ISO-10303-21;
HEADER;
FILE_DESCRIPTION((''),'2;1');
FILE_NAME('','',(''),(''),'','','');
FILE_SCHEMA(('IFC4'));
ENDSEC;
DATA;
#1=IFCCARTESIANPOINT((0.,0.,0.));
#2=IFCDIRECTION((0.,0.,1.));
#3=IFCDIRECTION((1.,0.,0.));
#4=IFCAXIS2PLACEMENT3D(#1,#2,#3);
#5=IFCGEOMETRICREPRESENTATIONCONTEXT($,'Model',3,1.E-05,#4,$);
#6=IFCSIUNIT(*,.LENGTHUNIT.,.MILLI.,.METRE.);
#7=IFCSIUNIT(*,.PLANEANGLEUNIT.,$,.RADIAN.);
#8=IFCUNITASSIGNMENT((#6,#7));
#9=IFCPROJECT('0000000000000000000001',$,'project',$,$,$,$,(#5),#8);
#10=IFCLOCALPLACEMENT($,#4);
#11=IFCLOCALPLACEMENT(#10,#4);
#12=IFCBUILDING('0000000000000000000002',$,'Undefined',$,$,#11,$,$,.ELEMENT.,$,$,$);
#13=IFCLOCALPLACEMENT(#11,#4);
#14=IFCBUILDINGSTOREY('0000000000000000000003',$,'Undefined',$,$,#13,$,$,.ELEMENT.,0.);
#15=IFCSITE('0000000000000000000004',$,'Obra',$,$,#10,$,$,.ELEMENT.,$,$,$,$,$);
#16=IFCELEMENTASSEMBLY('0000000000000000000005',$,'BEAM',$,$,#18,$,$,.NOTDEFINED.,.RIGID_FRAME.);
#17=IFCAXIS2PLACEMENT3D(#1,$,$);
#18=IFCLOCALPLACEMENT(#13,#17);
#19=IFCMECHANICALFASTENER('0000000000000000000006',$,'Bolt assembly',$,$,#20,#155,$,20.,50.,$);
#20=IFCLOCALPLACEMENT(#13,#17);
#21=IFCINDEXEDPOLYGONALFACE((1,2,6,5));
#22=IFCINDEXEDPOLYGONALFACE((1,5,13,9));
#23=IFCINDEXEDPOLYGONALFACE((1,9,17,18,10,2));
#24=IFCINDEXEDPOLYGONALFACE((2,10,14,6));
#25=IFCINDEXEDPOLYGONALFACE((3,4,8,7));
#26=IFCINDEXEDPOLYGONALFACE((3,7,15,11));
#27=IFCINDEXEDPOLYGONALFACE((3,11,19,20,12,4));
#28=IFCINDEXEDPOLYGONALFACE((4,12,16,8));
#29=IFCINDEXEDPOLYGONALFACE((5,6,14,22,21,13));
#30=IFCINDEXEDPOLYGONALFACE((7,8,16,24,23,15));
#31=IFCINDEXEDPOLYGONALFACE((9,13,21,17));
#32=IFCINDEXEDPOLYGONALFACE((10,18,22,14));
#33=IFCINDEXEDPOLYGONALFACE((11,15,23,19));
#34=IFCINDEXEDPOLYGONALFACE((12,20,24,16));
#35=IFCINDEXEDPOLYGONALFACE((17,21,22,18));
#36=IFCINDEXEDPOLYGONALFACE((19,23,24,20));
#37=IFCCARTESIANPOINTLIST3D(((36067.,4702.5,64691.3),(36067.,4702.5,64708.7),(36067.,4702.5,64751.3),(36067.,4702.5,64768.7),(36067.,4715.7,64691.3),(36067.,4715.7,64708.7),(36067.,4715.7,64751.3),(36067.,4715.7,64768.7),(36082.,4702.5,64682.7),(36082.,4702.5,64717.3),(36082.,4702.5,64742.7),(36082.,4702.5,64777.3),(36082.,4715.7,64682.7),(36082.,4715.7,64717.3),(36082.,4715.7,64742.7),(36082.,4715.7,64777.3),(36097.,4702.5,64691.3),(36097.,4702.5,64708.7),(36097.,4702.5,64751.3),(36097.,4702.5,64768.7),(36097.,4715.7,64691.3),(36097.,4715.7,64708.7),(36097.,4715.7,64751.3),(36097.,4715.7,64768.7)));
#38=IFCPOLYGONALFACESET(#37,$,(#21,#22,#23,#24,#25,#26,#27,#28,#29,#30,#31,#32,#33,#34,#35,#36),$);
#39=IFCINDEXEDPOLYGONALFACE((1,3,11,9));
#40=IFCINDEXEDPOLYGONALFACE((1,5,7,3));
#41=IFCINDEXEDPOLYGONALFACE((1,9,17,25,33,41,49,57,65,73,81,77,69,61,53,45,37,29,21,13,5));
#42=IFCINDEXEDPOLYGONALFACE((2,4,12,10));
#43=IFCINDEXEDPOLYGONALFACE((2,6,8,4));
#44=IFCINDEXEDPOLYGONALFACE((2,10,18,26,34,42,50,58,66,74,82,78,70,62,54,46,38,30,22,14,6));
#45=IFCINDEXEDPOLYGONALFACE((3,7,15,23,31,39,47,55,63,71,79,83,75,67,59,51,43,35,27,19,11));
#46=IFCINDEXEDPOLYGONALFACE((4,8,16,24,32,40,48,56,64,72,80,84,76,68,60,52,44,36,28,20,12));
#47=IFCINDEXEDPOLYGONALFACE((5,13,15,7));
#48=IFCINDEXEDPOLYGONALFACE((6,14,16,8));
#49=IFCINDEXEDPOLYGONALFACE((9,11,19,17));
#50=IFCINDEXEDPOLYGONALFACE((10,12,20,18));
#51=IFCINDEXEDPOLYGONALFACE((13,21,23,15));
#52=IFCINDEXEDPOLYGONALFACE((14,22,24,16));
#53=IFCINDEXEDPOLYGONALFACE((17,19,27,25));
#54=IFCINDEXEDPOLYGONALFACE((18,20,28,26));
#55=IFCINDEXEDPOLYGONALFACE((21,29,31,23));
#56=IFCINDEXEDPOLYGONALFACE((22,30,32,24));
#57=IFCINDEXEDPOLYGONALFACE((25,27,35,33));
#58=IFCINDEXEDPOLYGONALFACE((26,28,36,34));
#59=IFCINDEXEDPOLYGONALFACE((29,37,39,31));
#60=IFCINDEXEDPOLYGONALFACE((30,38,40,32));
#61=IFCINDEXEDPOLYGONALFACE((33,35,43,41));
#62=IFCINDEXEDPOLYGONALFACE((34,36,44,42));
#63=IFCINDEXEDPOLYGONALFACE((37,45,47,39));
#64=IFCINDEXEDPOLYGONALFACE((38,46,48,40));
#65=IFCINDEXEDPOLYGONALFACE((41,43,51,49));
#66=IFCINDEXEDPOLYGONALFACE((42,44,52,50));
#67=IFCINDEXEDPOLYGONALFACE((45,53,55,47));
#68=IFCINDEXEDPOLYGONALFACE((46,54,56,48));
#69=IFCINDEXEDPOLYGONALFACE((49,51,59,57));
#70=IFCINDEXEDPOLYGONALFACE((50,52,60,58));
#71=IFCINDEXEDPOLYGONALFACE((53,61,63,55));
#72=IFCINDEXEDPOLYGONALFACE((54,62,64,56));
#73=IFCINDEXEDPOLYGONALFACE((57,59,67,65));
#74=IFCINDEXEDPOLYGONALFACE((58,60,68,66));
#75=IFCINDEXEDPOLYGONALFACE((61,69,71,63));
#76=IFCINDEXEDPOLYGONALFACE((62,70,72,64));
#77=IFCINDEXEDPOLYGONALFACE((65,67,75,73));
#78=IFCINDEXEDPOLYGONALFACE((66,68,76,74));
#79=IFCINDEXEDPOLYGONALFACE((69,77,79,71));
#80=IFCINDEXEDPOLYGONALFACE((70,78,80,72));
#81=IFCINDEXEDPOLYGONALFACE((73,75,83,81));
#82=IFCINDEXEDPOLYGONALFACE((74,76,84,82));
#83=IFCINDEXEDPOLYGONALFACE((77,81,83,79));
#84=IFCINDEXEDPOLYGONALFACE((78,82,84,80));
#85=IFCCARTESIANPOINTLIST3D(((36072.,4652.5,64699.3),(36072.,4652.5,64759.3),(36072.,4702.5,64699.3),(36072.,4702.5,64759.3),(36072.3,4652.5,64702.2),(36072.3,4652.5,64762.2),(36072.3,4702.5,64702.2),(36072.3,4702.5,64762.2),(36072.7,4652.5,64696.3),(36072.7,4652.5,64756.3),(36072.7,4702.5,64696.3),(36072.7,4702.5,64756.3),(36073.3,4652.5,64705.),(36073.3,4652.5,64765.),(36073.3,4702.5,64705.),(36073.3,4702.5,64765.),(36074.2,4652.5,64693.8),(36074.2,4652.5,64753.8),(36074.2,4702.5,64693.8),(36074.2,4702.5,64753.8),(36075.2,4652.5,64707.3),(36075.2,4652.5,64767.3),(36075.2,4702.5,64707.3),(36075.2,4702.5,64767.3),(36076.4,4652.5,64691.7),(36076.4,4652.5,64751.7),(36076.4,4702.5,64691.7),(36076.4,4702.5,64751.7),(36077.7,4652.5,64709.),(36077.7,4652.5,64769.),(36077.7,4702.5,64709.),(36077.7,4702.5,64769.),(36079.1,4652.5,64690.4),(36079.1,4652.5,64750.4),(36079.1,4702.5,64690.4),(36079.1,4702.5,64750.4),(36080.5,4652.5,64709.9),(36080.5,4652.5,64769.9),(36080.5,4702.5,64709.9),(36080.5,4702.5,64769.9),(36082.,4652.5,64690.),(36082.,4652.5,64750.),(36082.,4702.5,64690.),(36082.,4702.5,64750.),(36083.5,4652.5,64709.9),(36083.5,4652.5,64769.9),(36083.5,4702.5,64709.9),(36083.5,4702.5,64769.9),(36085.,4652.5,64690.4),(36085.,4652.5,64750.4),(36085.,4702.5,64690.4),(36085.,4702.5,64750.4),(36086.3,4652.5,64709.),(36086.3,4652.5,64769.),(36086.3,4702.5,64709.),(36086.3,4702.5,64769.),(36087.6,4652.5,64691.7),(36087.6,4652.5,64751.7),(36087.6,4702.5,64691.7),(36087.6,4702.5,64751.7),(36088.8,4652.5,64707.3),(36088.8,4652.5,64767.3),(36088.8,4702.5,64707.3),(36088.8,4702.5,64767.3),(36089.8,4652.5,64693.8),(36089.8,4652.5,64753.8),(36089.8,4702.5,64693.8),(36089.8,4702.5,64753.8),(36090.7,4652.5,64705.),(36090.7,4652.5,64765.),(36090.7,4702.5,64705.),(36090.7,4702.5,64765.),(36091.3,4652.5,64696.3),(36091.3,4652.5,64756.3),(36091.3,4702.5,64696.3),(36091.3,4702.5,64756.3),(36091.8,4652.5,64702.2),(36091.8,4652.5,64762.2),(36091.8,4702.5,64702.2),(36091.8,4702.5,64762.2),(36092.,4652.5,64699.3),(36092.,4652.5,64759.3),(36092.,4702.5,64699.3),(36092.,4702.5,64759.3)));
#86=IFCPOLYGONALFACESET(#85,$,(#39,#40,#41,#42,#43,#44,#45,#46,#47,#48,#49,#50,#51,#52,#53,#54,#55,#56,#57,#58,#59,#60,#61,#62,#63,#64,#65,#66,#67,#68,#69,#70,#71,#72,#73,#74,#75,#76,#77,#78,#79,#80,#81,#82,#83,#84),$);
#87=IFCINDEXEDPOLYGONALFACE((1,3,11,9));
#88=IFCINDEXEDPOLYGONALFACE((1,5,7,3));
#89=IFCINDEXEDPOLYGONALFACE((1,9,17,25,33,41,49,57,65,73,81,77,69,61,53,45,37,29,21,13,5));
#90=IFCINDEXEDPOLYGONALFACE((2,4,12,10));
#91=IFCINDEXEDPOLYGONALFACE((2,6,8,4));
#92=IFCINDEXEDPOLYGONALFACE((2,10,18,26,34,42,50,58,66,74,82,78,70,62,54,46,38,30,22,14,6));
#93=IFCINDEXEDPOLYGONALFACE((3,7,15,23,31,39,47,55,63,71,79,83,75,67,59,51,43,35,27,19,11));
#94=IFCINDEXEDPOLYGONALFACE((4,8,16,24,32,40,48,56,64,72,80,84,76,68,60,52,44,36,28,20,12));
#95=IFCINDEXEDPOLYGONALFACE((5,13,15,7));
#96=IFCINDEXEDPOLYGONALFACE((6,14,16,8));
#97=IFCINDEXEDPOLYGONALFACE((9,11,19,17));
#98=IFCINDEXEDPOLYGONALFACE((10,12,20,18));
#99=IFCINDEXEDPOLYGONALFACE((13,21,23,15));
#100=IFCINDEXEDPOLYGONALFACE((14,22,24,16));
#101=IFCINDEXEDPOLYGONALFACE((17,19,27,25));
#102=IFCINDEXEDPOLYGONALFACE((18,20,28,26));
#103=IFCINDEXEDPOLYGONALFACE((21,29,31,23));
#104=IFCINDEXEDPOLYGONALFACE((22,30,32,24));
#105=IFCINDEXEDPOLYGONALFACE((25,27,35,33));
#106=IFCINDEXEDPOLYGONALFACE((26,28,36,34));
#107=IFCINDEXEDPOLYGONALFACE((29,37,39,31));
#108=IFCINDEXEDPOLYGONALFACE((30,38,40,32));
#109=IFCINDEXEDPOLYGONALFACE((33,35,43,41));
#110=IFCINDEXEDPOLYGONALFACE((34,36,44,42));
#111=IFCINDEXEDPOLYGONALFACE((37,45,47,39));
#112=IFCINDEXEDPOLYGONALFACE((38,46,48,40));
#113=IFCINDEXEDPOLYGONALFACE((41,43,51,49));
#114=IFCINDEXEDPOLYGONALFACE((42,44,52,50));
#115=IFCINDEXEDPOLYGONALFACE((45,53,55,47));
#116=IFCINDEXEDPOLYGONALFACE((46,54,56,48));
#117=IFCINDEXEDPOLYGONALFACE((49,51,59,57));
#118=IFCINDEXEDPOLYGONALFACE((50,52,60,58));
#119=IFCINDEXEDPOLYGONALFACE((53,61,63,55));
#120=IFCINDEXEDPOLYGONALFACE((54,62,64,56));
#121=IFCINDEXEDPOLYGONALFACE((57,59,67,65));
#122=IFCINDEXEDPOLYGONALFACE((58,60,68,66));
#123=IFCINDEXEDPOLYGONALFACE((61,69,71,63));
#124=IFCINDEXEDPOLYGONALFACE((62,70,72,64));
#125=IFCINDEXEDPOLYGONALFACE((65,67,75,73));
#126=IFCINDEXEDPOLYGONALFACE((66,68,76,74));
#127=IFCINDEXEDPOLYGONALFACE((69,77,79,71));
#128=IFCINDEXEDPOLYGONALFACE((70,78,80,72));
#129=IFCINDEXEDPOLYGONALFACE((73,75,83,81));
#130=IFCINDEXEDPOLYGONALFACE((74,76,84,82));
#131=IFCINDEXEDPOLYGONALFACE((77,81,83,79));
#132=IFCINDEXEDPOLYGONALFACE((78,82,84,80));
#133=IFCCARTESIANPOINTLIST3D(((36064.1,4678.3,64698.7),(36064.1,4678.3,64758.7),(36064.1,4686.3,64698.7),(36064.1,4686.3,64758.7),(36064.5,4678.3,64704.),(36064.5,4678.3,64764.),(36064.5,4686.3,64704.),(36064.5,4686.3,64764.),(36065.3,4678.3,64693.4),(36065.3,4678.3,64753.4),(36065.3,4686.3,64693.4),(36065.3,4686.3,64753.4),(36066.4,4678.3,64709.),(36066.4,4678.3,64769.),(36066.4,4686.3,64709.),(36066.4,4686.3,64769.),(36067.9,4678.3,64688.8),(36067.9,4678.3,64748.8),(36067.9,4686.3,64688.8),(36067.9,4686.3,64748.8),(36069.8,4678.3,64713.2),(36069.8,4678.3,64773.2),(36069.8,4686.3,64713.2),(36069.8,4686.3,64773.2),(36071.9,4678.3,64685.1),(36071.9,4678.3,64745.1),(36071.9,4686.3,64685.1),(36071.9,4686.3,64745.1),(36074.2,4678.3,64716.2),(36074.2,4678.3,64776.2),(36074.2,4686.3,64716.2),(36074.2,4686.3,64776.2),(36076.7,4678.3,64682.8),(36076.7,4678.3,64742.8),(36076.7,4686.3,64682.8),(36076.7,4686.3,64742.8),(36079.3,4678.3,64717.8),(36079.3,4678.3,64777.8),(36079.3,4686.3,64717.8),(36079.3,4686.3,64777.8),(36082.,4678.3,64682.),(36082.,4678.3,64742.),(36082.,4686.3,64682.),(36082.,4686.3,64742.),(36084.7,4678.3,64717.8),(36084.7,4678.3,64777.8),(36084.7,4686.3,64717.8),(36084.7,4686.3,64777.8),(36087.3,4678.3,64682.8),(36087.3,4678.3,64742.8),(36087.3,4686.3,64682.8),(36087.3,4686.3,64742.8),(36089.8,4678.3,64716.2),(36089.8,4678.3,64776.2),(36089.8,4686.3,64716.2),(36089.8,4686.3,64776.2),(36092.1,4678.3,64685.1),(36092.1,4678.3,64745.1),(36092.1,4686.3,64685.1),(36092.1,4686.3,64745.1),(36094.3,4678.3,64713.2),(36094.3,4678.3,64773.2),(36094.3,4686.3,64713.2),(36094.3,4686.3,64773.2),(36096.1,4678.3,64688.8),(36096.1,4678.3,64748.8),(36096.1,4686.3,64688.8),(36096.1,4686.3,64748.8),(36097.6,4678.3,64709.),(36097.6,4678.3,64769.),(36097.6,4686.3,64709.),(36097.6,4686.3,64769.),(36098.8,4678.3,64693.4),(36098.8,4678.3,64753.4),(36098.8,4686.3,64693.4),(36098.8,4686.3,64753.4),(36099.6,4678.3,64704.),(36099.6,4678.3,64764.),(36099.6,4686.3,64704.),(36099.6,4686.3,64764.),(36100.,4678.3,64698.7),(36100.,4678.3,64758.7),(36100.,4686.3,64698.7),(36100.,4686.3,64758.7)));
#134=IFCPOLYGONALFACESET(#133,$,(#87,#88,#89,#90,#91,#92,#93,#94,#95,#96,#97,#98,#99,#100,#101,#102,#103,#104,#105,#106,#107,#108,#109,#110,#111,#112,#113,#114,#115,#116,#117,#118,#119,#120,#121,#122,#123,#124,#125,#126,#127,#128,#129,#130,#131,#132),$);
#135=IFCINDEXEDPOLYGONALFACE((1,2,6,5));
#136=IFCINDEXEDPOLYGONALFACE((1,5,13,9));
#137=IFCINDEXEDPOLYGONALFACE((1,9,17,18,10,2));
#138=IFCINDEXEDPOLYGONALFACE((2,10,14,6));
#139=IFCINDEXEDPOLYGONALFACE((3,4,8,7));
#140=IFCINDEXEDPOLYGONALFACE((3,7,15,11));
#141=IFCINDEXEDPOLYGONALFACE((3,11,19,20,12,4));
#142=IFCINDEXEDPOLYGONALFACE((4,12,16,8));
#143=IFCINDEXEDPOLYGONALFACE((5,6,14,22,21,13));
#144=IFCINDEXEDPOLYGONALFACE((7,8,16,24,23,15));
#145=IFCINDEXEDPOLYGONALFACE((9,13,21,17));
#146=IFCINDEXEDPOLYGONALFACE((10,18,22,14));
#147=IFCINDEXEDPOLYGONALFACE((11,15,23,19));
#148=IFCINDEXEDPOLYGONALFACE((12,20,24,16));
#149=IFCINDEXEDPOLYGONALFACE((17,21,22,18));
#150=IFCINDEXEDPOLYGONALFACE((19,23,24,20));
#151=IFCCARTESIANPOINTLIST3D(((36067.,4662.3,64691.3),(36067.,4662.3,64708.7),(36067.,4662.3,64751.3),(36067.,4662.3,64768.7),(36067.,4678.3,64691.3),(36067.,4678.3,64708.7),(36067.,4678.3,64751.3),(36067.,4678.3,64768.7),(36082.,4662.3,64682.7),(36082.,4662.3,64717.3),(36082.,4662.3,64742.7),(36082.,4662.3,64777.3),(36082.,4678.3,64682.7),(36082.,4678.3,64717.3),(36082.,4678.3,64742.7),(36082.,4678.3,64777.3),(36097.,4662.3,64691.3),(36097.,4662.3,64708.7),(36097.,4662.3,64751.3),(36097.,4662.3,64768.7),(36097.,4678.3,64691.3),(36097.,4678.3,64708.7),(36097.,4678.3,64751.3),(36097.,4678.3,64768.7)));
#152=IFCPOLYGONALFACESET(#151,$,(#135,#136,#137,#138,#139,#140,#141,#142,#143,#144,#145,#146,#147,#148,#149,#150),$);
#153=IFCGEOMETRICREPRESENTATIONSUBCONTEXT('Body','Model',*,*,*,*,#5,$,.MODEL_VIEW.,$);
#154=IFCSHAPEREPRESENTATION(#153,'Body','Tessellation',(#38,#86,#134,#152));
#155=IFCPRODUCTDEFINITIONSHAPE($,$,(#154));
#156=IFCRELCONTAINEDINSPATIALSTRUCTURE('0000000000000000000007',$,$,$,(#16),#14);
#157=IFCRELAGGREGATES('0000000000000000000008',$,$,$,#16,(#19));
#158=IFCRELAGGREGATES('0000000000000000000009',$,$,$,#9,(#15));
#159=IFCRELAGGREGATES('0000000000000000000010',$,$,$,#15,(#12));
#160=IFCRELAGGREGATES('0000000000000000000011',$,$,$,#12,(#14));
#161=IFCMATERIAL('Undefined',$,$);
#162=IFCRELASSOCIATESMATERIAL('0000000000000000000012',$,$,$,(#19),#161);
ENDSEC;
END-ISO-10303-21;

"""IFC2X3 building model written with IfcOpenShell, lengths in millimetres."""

from ifc_helpers import new_model, si_unit, frame, origin_with_axes, origin_2d_with_axis, place, context, subcontext, project, spatial, polyline, circle, outline, extrude, source, transform, mapped, material, element, aggregate, save


model = new_model("IFC2X3")

# Units and contexts
model_context = context("Model", 3, precision=1e-05, world=origin_with_axes())
body_context = subcontext(model_context, "Body", "Model", "MODEL_VIEW")
ifc_project = project(units=[si_unit("LENGTHUNIT", "METRE", prefix="MILLI"), si_unit("PLANEANGLEUNIT", "RADIAN")], contexts=[model_context])

# Site, building, storey
site_placement = place(None, origin_with_axes())
site = spatial("IfcSite", under=ifc_project, at=site_placement, Name="Obra", CompositionType="ELEMENT")
building_placement = place(site_placement, origin_with_axes())
building = spatial("IfcBuilding", under=site, at=building_placement, Name="Undefined", CompositionType="ELEMENT")
storey_placement = place(building_placement, origin_with_axes())
storey = spatial("IfcBuildingStorey", under=building, at=storey_placement, Name="Undefined", CompositionType="ELEMENT", Elevation=0.0)

# Shared definitions
ifc_material = material(Name="Undefined")

# Element assembly, mechanical fastener
shared_shape_1 = source(origin_with_axes(), body_context, "Body", "SweptSolid", [
    extrude(outline(polyline([(17.3, 0.0), (8.7, 15.0), (-8.7, 15.0), (-17.3, 0.0), (-8.7, -15.0), (8.7, -15.0), (17.3, 0.0)])), frame((0.0, -26.3, 0.0), z_axis=(0.0, 1.0, 0.0), x_axis=(1.0, 0.0, 0.0)), (0.0, 0.0, 1.0), 13.2),
    extrude(circle(Radius=10.0, at=origin_2d_with_axis()), frame((0.0, -13.1, 0.0), z_axis=(0.0, 1.0, 0.0), x_axis=(1.0, 0.0, 0.0)), (0.0, 0.0, 1.0), 50.0),
    extrude(circle(Radius=18.0, at=origin_2d_with_axis()), frame((0.0, 3.1, 0.0), z_axis=(0.0, 1.0, 0.0), x_axis=(1.0, 0.0, 0.0)), (0.0, 0.0, 1.0), 8.0),
    extrude(outline(polyline([(17.3, 0.0), (8.7, 15.0), (-8.7, 15.0), (-17.3, 0.0), (-8.7, -15.0), (8.7, -15.0), (17.3, 0.0)])), frame((0.0, 11.1, 0.0), z_axis=(0.0, 1.0, 0.0), x_axis=(1.0, 0.0, 0.0)), (0.0, 0.0, 1.0), 16.0),
])
assembly_1_placement = place(storey_placement, origin_with_axes())
assembly_1 = element("IfcElementAssembly", 1, at=assembly_1_placement, inside=storey, Name="BEAM", AssemblyPlace="NOTDEFINED", PredefinedType="RIGID_FRAME")
mechanical_fastener_1_placement = place(assembly_1_placement, frame((36122.0, 4689.4, 64850.0), z_axis=(-1.0, 0.0, 0.0), x_axis=(0.0, 0.0, -1.0)))
mechanical_fastener_1 = element("IfcMechanicalFastener", 2, at=mechanical_fastener_1_placement, material=ifc_material, Name="Bolt assembly", NominalDiameter=20.0, NominalLength=50.0, context=body_context, shape_type="MappedRepresentation", body=[
    mapped(shared_shape_1, transform((90.0, 0.0, 40.0))),
    mapped(shared_shape_1, transform((150.0, 0.0, 40.0))),
])

aggregate(assembly_1, [mechanical_fastener_1])

save(model, "model.ifc")
